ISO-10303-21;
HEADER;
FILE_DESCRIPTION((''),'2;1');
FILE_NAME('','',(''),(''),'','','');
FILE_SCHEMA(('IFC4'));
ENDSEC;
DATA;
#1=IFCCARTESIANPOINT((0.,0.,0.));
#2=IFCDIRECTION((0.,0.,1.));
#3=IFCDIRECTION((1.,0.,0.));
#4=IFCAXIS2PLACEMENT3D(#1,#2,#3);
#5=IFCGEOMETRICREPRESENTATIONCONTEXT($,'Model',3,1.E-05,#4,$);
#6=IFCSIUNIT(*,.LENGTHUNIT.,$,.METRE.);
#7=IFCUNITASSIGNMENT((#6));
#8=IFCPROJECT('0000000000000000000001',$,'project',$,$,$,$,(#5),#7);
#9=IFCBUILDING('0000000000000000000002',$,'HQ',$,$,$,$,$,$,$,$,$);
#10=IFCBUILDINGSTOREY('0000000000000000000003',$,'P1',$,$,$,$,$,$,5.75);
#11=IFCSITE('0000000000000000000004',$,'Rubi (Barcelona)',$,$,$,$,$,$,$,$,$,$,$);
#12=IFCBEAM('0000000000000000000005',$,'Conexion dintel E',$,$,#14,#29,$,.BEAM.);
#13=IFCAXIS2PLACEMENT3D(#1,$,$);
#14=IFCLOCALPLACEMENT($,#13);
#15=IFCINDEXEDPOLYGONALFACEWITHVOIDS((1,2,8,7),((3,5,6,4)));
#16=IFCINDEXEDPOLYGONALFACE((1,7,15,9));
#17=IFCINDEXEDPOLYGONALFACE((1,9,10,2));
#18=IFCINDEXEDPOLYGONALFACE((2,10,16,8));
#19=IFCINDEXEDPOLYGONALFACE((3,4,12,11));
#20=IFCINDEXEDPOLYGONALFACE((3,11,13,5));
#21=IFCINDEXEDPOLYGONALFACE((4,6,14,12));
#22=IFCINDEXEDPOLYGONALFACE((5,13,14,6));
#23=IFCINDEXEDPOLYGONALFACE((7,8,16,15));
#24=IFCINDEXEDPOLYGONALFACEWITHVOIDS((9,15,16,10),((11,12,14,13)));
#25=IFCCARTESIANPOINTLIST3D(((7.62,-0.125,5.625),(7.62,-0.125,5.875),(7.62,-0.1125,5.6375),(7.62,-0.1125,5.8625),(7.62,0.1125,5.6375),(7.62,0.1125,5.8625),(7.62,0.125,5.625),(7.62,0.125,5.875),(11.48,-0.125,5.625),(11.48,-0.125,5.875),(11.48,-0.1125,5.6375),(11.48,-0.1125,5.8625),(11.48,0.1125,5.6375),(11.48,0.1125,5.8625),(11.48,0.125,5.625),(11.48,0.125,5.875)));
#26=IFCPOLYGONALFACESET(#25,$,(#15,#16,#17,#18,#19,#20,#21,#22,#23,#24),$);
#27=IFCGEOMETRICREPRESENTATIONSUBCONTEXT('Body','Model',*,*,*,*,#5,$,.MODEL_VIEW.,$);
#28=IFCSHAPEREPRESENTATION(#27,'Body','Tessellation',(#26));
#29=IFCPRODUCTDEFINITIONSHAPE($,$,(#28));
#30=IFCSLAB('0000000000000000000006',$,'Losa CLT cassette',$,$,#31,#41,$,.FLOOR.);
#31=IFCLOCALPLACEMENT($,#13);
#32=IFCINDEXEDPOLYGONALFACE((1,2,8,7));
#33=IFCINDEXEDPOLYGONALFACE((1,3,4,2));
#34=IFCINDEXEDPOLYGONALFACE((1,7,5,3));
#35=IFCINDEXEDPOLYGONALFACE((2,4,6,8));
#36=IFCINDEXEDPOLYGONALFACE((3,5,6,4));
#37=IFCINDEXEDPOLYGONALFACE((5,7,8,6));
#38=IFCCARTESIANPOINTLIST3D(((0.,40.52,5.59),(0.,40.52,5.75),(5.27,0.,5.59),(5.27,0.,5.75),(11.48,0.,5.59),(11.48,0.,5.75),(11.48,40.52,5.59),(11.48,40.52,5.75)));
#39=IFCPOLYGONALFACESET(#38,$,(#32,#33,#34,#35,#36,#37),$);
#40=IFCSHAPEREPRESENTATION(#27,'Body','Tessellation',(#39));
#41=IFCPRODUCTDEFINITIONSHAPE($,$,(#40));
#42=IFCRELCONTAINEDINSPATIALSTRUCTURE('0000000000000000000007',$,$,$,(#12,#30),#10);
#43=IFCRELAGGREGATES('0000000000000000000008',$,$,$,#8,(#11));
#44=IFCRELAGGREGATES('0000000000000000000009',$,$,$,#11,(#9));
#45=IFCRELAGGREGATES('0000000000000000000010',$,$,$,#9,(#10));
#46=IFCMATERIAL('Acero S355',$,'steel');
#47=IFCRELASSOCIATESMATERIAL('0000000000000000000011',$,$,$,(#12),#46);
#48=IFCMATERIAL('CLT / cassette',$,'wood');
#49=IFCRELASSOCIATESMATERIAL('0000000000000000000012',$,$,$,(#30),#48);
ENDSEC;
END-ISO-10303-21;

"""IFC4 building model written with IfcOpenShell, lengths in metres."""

from ifc_helpers import new_model, si_unit, frame, origin_with_axes, place, context, subcontext, project, spatial, polyline, hollow_rectangle, outline, extrude, material, element, save


model = new_model("IFC4")

# Units and contexts
model_context = context("Model", 3, precision=1e-05, world=origin_with_axes())
body_context = subcontext(model_context, "Body", "Model", "MODEL_VIEW")
ifc_project = project(units=[si_unit("LENGTHUNIT", "METRE")], contexts=[model_context])

# Site, building, storey
site = spatial("IfcSite", under=ifc_project, Name="Rubi (Barcelona)")
building = spatial("IfcBuilding", under=site, Name="HQ")
storey = spatial("IfcBuildingStorey", under=building, Name="P1", Elevation=5.75)

# Beam
ifc_material_1 = material(Name="Acero S355", Category="steel")
beam_1_placement = place(None, origin_with_axes())
element("IfcBeam", 1, at=beam_1_placement, inside=storey, material=ifc_material_1, Name="Conexion dintel E", PredefinedType="BEAM", context=body_context, shape_type="SweptSolid", body=[
    extrude(hollow_rectangle(XDim=0.25, YDim=0.25, WallThickness=0.0125), frame((7.62, 0.0, 5.75), z_axis=(1.0, 0.0, 0.0), x_axis=(0.0, 1.0, 0.0)), (0.0, 0.0, 1.0), 3.86),
])

# Slab
ifc_material_2 = material(Name="CLT / cassette", Category="wood")
slab_placement = place(None, origin_with_axes())
element("IfcSlab", 2, at=slab_placement, inside=storey, material=ifc_material_2, Name="Losa CLT cassette", PredefinedType="FLOOR", context=body_context, shape_type="SweptSolid", body=[
    extrude(outline(polyline([(5.27, 0.0, 0.0), (11.48, 0.0, 0.0), (11.48, 40.52, 0.0), (0.0, 40.52, 0.0), (5.27, 0.0, 0.0)])), frame((0.0, 0.0, 5.59)), (0.0, 0.0, 1.0), 0.16),
])

save(model, "model.ifc")
